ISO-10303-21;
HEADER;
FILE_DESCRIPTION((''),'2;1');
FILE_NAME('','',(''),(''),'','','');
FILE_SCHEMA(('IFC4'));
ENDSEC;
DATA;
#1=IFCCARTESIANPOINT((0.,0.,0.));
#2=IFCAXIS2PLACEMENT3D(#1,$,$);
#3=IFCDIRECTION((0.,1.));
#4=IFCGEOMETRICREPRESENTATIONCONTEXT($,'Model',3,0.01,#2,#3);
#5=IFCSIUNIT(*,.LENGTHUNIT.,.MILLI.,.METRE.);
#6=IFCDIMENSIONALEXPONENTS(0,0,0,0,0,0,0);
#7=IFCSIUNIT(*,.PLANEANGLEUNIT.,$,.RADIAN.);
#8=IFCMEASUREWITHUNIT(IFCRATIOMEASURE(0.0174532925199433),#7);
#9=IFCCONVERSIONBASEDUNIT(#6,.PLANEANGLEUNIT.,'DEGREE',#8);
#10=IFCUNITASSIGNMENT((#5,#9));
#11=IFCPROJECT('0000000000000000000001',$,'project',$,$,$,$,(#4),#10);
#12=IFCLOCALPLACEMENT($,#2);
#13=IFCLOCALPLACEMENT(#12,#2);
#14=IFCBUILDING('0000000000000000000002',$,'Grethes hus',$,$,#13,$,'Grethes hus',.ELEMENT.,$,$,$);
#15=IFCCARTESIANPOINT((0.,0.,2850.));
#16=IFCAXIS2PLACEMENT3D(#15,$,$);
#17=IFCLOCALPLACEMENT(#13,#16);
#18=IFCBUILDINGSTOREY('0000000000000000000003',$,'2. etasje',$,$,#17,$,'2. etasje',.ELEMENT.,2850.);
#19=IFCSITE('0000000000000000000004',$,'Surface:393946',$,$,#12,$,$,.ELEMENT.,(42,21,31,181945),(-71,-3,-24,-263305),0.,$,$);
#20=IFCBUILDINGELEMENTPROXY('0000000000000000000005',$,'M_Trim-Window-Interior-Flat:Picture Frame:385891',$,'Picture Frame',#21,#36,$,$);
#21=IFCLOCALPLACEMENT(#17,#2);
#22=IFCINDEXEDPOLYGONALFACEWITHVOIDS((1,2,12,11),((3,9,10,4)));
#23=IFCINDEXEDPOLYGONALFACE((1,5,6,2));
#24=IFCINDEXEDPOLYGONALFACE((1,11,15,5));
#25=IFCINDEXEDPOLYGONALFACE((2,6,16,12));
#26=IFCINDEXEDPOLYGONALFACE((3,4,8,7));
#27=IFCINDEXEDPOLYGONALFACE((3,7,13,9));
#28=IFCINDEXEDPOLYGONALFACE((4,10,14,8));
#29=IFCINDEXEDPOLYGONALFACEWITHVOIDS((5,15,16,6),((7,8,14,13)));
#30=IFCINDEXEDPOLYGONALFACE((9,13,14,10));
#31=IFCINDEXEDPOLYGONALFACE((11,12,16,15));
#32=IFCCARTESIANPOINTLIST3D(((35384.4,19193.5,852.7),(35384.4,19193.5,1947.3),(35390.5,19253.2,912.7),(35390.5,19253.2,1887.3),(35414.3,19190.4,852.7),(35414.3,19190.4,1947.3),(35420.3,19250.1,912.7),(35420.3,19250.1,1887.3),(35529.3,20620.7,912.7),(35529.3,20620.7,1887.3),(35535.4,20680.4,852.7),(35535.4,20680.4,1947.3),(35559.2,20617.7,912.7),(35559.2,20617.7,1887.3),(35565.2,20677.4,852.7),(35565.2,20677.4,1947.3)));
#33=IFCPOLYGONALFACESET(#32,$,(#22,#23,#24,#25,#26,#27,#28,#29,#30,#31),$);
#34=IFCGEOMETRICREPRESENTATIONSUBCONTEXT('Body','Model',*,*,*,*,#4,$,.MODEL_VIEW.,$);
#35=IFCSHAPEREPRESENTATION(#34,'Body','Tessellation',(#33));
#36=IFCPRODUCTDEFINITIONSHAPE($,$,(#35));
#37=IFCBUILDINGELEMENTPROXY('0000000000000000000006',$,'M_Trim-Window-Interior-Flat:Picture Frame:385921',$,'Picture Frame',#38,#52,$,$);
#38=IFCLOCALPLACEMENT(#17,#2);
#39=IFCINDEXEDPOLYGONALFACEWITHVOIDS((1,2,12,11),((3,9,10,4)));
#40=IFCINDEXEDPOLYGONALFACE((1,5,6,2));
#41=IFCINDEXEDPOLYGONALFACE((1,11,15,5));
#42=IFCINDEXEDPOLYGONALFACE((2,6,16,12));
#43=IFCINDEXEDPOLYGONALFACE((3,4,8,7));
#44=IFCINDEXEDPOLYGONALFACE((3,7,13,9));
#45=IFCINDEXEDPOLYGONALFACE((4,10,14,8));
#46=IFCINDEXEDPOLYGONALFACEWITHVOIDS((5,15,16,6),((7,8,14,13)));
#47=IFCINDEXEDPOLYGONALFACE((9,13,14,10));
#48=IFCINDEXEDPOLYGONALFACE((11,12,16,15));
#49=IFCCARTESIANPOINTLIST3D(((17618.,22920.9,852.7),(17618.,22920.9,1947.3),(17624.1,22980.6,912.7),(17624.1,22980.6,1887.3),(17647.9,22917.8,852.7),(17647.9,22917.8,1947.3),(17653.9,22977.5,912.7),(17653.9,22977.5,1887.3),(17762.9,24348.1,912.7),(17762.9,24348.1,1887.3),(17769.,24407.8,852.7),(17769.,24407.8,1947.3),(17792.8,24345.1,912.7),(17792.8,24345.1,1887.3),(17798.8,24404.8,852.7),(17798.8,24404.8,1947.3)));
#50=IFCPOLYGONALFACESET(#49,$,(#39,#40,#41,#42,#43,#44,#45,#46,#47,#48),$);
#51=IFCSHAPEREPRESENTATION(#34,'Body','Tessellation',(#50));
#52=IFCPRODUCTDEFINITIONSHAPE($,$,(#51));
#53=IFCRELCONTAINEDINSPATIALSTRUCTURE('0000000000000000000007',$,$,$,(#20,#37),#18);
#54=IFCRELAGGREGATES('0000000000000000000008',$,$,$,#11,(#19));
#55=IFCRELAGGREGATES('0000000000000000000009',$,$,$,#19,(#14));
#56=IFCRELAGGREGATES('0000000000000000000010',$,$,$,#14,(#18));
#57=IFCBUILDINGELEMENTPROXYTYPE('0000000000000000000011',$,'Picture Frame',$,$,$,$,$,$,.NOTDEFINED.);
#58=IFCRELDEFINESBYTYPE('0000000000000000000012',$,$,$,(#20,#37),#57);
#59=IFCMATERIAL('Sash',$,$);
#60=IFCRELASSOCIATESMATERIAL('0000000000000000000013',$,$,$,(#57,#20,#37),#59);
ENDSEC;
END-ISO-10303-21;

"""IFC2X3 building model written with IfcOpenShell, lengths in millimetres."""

from ifc_helpers import new_model, entity, si_unit, converted_unit, direction, frame, origin, place, context, subcontext, project, spatial, polyline, outline, extrude, source, transform, mapped, material, type_object, type_shapes, element, save


model = new_model("IFC2X3")

# Units and contexts
model_context = context("Model", 3, precision=0.01, world=origin(), true_north=direction((0.0, 1.0)))
body_context = subcontext(model_context, "Body", "Model", "MODEL_VIEW")
ifc_project = project(units=[si_unit("LENGTHUNIT", "METRE", prefix="MILLI"), converted_unit("PLANEANGLEUNIT", "DEGREE", entity("IfcRatioMeasure", 0.0174532925199433), si_unit("PLANEANGLEUNIT", "RADIAN"), dimensions=[0, 0, 0, 0, 0, 0, 0])], contexts=[model_context])

# Site, building, storey
site_placement = place(None, origin())
site = spatial("IfcSite", under=ifc_project, at=site_placement, Name="Surface:393946", CompositionType="ELEMENT", RefLatitude=(42, 21, 31, 181945), RefLongitude=(-71, -3, -24, -263305), RefElevation=0.0)
building_placement = place(site_placement, origin())
building = spatial("IfcBuilding", under=site, at=building_placement, Name="Grethes hus", LongName="Grethes hus", CompositionType="ELEMENT")
storey_placement = place(building_placement, frame((0.0, 0.0, 2850.0)))
storey = spatial("IfcBuildingStorey", under=building, at=storey_placement, Name="2. etasje", LongName="2. etasje", CompositionType="ELEMENT", Elevation=2850.0)

# Building element proxies
ifc_material_1 = material(Name="Sash")
building_element_proxy_type_1 = type_object("IfcBuildingElementProxyType", Name="Picture Frame", PredefinedType="NOTDEFINED", material=ifc_material_1)
shared_shape_1 = source(origin(), body_context, "Body", "SweptSolid", [
    extrude(outline(polyline([(-547.3, -747.3), (547.3, -747.3), (547.3, 747.3), (-547.3, 747.3), (-547.3, -747.3)]), holes=[polyline([(-487.3, -687.3), (-487.3, 687.3), (487.3, 687.3), (487.3, -687.3), (-487.3, -687.3)])]), frame((0.0, 500.0, 0.0), z_axis=(0.0, 0.0, 1.0), x_axis=(0.0, 1.0, 0.0)), (0.0, 0.0, 1.0), 30.0),
])
type_shapes(building_element_proxy_type_1, [shared_shape_1])
for number, where, z_axis, x_axis, name in (
    (1, (35489.7, 19933.9, 1900.0), (-0.994887, 0.100996, 0.0), (0.100996, 0.994887, 0.0), "M_Trim-Window-Interior-Flat:Picture Frame:385891"),
    (2, (17693.5, 23664.3, 1900.0), (0.994887, -0.100996, 0.0), (-0.100996, -0.994887, 0.0), "M_Trim-Window-Interior-Flat:Picture Frame:385921"),
):
    element("IfcBuildingElementProxy", number, at=place(storey_placement, frame(where, z_axis=z_axis, x_axis=x_axis)), inside=storey, type_object=building_element_proxy_type_1, material=ifc_material_1, Name=name, ObjectType="Picture Frame", context=body_context, shape_type="MappedRepresentation", body=[
        mapped(shared_shape_1, transform((0.0, 0.0, 0.0), scale=1.0)),
    ])

save(model, "model.ifc")
